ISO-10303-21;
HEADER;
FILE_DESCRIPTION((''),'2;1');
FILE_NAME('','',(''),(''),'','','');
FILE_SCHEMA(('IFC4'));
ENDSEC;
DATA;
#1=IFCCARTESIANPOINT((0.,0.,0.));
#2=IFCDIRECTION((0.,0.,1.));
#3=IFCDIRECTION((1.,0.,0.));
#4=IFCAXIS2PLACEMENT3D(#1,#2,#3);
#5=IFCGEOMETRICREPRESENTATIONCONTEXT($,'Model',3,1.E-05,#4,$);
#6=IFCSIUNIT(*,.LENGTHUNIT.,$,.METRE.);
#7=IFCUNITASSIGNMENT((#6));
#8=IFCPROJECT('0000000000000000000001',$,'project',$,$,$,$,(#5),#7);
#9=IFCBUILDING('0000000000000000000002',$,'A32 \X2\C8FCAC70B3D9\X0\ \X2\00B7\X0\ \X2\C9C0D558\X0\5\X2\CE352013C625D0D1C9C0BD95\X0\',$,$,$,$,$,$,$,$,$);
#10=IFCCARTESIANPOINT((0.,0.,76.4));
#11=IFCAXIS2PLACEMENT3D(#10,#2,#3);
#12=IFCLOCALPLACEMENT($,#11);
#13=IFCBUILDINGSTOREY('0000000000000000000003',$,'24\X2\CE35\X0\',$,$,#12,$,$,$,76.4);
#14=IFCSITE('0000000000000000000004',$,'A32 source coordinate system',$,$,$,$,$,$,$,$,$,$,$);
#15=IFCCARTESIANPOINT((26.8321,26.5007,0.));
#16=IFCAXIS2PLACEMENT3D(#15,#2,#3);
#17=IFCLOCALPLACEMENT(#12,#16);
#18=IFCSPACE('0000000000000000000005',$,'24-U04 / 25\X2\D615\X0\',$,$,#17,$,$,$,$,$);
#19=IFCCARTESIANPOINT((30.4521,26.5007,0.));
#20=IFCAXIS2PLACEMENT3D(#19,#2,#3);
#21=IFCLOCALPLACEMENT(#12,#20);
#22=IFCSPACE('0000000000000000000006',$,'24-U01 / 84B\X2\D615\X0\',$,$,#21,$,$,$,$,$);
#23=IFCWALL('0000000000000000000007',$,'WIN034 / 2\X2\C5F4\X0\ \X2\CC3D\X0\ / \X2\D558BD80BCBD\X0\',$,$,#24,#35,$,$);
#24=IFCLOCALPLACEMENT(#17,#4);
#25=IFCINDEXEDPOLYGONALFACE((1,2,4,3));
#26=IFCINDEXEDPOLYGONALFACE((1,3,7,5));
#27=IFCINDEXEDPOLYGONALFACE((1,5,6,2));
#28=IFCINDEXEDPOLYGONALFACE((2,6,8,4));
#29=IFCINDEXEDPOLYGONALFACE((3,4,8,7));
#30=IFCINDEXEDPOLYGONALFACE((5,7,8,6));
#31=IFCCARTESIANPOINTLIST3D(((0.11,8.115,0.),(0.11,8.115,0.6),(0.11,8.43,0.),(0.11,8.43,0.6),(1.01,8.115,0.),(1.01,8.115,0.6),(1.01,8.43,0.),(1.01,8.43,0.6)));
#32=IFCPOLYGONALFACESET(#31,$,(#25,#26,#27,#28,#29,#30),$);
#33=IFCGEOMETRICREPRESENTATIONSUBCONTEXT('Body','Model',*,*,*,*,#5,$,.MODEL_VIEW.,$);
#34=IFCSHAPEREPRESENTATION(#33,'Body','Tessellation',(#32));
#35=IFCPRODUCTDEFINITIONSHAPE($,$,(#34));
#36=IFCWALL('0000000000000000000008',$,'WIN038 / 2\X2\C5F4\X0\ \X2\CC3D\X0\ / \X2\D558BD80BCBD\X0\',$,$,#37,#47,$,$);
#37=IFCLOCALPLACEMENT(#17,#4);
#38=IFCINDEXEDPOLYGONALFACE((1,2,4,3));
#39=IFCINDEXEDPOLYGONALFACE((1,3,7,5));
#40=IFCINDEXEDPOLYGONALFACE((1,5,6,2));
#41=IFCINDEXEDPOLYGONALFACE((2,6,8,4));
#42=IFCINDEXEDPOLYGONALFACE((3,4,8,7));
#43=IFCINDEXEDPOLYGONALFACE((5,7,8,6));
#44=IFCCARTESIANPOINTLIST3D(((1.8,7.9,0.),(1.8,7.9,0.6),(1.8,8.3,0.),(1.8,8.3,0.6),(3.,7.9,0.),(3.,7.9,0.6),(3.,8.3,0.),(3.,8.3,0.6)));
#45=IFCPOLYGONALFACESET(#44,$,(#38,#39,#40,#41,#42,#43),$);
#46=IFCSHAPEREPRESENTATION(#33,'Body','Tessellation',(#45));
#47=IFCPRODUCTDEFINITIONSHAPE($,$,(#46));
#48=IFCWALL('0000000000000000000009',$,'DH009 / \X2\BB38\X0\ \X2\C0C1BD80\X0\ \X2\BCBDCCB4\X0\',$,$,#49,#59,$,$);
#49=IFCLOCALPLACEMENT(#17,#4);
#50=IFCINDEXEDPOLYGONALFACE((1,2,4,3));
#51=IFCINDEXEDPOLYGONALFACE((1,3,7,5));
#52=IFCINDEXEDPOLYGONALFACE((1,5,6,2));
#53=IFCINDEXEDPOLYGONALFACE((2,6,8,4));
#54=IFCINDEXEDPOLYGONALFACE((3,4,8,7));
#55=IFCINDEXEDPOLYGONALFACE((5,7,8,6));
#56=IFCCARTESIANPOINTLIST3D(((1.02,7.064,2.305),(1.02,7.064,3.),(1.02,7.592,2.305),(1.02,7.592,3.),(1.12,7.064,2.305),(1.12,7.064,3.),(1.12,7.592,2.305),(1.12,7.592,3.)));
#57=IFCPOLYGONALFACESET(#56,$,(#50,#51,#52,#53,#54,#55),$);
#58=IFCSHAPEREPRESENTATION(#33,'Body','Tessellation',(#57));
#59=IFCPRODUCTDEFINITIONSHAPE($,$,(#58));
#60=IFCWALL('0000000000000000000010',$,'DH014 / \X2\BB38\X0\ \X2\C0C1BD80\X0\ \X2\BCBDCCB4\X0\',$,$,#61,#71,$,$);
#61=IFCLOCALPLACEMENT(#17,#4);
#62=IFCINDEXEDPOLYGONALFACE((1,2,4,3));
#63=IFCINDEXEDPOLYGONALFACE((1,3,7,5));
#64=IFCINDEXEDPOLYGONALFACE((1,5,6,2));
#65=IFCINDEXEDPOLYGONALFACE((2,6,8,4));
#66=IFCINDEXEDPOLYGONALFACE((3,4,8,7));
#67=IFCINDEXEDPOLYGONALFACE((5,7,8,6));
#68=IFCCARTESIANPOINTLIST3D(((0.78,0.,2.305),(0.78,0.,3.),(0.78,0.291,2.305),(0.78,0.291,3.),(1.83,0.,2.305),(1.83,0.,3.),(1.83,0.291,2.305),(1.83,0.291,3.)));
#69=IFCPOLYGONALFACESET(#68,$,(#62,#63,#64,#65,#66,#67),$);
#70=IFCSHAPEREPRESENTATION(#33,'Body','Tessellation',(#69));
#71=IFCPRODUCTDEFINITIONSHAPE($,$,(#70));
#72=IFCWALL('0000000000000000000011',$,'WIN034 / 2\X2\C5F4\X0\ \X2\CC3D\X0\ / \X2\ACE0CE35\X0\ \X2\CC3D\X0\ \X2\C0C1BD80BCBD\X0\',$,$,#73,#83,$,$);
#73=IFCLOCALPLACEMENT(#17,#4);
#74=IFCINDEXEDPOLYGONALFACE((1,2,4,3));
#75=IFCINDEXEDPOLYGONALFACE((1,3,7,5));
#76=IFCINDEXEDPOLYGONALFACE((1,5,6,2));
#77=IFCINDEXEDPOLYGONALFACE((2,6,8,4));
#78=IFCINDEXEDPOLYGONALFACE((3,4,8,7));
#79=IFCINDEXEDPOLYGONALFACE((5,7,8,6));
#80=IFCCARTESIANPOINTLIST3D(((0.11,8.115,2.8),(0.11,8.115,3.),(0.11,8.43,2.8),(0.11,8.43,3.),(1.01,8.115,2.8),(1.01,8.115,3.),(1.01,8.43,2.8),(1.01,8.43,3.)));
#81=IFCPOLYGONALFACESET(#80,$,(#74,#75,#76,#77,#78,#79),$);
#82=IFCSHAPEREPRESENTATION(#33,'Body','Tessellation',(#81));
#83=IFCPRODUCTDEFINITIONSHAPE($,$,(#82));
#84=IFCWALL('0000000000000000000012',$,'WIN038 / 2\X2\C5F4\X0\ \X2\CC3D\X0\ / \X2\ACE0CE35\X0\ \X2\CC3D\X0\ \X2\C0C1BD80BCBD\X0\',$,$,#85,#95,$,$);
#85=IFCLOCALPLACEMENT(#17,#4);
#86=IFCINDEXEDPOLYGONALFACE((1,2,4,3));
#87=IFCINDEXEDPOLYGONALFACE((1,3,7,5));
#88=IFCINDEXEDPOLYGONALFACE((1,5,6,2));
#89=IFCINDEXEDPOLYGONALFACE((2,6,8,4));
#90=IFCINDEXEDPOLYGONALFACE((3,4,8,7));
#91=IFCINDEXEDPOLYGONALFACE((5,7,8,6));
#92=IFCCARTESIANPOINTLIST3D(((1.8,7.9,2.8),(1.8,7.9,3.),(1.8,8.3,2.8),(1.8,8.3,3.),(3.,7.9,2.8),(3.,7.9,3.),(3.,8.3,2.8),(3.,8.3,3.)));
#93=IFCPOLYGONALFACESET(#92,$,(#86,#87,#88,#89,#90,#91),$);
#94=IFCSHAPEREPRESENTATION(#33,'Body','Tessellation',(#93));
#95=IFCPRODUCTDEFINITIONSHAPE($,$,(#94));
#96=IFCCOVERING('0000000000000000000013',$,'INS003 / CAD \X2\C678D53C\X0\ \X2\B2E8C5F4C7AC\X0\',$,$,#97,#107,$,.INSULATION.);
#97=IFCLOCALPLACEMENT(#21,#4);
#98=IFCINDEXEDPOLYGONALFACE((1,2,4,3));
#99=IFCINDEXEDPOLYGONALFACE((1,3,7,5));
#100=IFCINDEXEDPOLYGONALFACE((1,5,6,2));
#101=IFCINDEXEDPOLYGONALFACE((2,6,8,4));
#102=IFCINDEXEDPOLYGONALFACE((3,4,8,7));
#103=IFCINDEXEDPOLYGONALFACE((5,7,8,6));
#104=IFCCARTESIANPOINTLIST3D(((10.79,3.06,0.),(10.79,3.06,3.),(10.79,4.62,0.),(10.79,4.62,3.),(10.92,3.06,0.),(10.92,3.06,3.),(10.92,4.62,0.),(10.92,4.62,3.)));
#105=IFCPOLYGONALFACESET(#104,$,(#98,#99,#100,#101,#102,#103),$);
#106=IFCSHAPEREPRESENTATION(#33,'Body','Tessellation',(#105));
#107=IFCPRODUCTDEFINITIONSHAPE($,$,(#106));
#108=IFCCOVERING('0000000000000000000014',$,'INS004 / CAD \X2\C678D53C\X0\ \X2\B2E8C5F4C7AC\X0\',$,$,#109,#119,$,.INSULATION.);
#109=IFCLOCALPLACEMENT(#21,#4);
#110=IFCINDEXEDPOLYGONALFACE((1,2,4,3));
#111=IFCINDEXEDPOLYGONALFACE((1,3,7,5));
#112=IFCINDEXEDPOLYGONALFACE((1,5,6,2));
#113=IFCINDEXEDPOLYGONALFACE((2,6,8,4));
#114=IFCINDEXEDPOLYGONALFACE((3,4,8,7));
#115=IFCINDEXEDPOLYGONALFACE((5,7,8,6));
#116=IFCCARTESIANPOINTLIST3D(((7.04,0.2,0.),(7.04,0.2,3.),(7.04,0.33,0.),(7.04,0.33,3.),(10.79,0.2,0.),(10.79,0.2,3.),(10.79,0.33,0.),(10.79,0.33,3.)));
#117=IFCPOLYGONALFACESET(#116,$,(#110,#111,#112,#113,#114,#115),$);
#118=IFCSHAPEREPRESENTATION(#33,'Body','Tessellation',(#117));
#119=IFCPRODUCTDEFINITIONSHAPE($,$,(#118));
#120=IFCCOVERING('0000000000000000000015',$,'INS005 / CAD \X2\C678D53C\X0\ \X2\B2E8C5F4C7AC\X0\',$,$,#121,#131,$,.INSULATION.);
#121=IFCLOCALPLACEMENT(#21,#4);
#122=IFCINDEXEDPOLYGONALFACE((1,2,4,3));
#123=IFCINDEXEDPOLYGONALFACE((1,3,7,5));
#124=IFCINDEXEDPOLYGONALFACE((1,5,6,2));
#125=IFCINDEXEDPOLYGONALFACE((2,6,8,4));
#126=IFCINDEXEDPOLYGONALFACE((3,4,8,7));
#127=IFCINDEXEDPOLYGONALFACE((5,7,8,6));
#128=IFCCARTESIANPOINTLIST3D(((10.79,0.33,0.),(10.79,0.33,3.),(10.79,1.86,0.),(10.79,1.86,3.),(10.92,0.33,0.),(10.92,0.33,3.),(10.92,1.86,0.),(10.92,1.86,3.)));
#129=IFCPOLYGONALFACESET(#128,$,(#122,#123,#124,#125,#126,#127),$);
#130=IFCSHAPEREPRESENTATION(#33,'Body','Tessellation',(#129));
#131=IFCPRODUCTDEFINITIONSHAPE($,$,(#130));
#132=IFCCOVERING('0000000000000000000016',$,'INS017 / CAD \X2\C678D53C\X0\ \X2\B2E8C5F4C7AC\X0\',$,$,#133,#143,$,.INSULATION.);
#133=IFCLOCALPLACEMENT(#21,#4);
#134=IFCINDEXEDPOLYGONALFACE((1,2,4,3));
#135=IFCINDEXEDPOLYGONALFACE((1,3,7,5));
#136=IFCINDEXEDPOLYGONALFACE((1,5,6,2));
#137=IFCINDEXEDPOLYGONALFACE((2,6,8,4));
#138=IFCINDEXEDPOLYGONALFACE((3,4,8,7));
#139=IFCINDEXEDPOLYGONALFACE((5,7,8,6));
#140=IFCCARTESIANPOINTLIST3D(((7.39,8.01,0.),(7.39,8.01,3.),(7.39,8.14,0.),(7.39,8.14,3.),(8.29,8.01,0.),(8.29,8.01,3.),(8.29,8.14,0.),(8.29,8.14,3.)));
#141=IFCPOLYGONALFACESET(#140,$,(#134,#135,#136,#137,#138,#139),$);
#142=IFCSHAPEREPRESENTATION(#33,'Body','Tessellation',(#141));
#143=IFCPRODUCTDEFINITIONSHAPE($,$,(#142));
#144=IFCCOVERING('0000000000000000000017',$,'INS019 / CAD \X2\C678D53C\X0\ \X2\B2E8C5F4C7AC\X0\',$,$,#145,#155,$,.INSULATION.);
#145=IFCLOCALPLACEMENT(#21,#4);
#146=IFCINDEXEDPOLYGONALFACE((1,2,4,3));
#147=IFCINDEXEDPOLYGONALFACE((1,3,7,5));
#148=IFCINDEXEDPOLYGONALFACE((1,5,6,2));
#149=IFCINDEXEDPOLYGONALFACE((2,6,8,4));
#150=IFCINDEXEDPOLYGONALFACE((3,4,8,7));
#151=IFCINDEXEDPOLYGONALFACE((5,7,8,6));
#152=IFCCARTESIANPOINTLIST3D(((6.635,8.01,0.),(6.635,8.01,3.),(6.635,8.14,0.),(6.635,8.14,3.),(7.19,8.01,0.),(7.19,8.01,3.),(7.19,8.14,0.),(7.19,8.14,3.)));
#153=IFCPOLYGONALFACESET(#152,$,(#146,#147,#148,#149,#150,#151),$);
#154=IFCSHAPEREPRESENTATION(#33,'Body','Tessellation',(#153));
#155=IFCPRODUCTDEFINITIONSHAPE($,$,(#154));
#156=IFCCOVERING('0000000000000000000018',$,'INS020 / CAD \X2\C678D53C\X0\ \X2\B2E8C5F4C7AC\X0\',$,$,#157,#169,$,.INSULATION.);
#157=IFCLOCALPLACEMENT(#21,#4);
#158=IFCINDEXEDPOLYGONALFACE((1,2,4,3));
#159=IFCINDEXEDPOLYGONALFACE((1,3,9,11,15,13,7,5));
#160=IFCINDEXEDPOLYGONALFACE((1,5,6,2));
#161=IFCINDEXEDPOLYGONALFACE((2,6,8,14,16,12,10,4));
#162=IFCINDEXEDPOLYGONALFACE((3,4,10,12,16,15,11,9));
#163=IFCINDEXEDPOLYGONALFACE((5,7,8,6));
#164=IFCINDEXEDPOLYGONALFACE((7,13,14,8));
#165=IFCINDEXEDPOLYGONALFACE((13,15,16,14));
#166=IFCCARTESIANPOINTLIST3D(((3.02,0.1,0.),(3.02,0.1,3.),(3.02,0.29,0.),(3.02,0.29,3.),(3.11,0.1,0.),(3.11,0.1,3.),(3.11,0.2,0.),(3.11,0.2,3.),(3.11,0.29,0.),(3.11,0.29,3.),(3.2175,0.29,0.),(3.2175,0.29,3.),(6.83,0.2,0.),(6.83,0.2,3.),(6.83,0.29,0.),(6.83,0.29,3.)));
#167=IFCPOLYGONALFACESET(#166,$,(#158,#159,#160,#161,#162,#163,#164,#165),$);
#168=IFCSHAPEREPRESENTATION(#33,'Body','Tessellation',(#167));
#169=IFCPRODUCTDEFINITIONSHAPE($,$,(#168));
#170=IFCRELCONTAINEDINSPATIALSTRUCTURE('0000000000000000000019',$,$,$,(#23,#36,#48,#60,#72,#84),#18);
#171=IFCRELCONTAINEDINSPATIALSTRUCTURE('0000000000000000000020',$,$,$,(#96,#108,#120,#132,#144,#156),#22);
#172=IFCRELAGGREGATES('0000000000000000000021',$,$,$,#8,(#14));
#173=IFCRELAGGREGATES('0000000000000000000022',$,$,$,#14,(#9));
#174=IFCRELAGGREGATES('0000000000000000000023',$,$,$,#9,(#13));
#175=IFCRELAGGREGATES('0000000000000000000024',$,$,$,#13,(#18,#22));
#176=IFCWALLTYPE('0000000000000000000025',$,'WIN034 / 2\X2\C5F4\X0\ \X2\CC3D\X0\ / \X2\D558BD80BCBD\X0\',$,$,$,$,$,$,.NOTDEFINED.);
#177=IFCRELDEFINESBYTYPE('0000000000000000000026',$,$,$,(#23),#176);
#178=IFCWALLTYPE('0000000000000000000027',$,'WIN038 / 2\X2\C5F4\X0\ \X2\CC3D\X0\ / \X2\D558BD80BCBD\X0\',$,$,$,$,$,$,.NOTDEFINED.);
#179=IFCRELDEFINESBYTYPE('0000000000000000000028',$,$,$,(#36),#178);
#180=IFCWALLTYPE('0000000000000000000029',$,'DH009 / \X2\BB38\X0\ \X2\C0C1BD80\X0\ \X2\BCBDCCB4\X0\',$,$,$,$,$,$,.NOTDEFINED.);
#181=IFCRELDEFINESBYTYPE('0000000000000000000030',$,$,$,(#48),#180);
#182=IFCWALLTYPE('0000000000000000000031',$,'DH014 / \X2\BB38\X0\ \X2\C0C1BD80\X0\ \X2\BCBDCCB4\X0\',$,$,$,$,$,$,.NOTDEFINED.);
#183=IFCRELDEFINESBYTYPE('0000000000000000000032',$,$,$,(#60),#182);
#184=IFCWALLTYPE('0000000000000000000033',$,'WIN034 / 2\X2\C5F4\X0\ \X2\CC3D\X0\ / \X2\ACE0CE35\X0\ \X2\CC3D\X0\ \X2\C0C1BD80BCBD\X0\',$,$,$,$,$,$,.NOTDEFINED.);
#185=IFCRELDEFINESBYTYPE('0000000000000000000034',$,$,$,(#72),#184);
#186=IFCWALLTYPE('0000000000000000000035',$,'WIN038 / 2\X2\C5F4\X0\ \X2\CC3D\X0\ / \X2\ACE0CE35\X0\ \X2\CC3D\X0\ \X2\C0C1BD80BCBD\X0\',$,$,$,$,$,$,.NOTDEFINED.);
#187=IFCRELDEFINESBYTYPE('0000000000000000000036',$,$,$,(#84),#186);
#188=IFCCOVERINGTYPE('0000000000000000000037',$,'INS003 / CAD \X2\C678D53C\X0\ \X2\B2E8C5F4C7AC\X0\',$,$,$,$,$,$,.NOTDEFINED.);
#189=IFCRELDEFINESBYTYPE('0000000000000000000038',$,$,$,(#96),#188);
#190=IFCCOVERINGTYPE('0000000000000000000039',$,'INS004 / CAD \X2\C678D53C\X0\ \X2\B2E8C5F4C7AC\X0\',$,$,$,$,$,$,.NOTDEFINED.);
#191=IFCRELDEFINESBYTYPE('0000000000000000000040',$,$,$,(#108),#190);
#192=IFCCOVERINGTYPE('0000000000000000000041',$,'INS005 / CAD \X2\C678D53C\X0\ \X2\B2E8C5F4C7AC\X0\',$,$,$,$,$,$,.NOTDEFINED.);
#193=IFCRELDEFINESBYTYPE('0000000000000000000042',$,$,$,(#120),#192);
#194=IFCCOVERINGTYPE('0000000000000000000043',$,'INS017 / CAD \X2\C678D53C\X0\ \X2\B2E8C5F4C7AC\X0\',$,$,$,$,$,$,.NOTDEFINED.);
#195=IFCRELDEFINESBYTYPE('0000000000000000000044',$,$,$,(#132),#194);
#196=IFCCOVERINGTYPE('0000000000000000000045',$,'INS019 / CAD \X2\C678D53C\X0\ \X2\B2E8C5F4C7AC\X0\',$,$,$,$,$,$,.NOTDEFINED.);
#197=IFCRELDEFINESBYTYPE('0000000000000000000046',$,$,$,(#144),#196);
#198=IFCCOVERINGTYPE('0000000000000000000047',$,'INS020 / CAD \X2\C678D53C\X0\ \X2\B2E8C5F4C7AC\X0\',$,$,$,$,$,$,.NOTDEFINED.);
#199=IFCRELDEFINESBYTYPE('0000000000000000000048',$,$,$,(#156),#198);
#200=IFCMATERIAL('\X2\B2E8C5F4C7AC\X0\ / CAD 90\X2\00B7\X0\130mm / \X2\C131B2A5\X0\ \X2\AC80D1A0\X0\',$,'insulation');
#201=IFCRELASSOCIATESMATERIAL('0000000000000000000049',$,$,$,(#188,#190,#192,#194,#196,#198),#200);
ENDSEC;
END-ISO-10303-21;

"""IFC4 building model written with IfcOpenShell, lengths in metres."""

from ifc_helpers import new_model, si_unit, frame, origin, origin_with_axes, place, context, subcontext, project, spatial, polyline, outline, extrude, source, transform, mapped, material, type_object, type_shapes, element, save


model = new_model("IFC4")

# Units and contexts
model_context = context("Model", 3, precision=1e-05, world=origin_with_axes())
body_context = subcontext(model_context, "Body", "Model", "MODEL_VIEW")
ifc_project = project(units=[si_unit("LENGTHUNIT", "METRE")], contexts=[model_context])

# Site, building, storey, space
site = spatial("IfcSite", under=ifc_project, Name="A32 source coordinate system")
building = spatial("IfcBuilding", under=site, Name="A32 주거동 · 지하5층–옥탑지붕")
storey_placement = place(None, frame((0.0, 0.0, 76.4), z_axis=(0.0, 0.0, 1.0), x_axis=(1.0, 0.0, 0.0)))
storey = spatial("IfcBuildingStorey", under=building, at=storey_placement, Name="24층", Elevation=76.4)
space_1_placement = place(storey_placement, frame((26.8321, 26.5007, 0.0), z_axis=(0.0, 0.0, 1.0), x_axis=(1.0, 0.0, 0.0)))
space_1 = spatial("IfcSpace", under=storey, at=space_1_placement, Name="24-U04 / 25형")

# Walls
wall_type_1 = type_object("IfcWallType", Name="WIN034 / 2열 창 / 하부벽", PredefinedType="NOTDEFINED")
shared_shape_1 = source(origin(), body_context, "Body", "SweptSolid", [
    extrude(outline(polyline([(0.11, 8.115), (0.11, 8.43), (1.01, 8.43), (1.01, 8.115), (0.11, 8.115)])), origin(), (0.0, 0.0, 1.0), 0.6),
])
type_shapes(wall_type_1, [shared_shape_1])
wall_1_placement = place(space_1_placement, origin_with_axes())
element("IfcWall", 1, at=wall_1_placement, inside=space_1, type_object=wall_type_1, Name="WIN034 / 2열 창 / 하부벽", context=body_context, shape_type="MappedRepresentation", body=[
    mapped(shared_shape_1, transform((0.0, 0.0, 0.0), scale=1.0)),
])
wall_type_2 = type_object("IfcWallType", Name="WIN038 / 2열 창 / 하부벽", PredefinedType="NOTDEFINED")
shared_shape_2 = source(origin(), body_context, "Body", "SweptSolid", [
    extrude(outline(polyline([(1.8, 7.9), (1.8, 8.3), (3.0, 8.3), (3.0, 7.9), (1.8, 7.9)])), origin(), (0.0, 0.0, 1.0), 0.6),
])
type_shapes(wall_type_2, [shared_shape_2])
wall_2_placement = place(space_1_placement, origin_with_axes())
element("IfcWall", 2, at=wall_2_placement, inside=space_1, type_object=wall_type_2, Name="WIN038 / 2열 창 / 하부벽", context=body_context, shape_type="MappedRepresentation", body=[
    mapped(shared_shape_2, transform((0.0, 0.0, 0.0), scale=1.0)),
])
wall_type_3 = type_object("IfcWallType", Name="DH009 / 문 상부 벽체", PredefinedType="NOTDEFINED")
shared_shape_3 = source(origin(), body_context, "Body", "SweptSolid", [
    extrude(outline(polyline([(1.02, 7.064), (1.02, 7.592), (1.12, 7.592), (1.12, 7.064), (1.02, 7.064)])), frame((0.0, 0.0, 2.305)), (0.0, 0.0, 1.0), 0.695),
])
type_shapes(wall_type_3, [shared_shape_3])
wall_3_placement = place(space_1_placement, origin_with_axes())
element("IfcWall", 3, at=wall_3_placement, inside=space_1, type_object=wall_type_3, Name="DH009 / 문 상부 벽체", context=body_context, shape_type="MappedRepresentation", body=[
    mapped(shared_shape_3, transform((0.0, 0.0, 0.0), scale=1.0)),
])
wall_type_4 = type_object("IfcWallType", Name="DH014 / 문 상부 벽체", PredefinedType="NOTDEFINED")
shared_shape_4 = source(origin(), body_context, "Body", "SweptSolid", [
    extrude(outline(polyline([(0.78, 0.291), (1.83, 0.291), (1.83, 0.0), (0.78, 0.0), (0.78, 0.291)])), frame((0.0, 0.0, 2.305)), (0.0, 0.0, 1.0), 0.695),
])
type_shapes(wall_type_4, [shared_shape_4])
wall_4_placement = place(space_1_placement, origin_with_axes())
element("IfcWall", 4, at=wall_4_placement, inside=space_1, type_object=wall_type_4, Name="DH014 / 문 상부 벽체", context=body_context, shape_type="MappedRepresentation", body=[
    mapped(shared_shape_4, transform((0.0, 0.0, 0.0), scale=1.0)),
])
wall_type_5 = type_object("IfcWallType", Name="WIN034 / 2열 창 / 고층 창 상부벽", PredefinedType="NOTDEFINED")
shared_shape_5 = source(origin(), body_context, "Body", "SweptSolid", [
    extrude(outline(polyline([(1.01, 8.115), (1.01, 8.43), (0.11, 8.43), (0.11, 8.115), (1.01, 8.115)])), frame((0.0, 0.0, 2.8)), (0.0, 0.0, 1.0), 0.2),
])
type_shapes(wall_type_5, [shared_shape_5])
wall_5_placement = place(space_1_placement, origin_with_axes())
element("IfcWall", 5, at=wall_5_placement, inside=space_1, type_object=wall_type_5, Name="WIN034 / 2열 창 / 고층 창 상부벽", context=body_context, shape_type="MappedRepresentation", body=[
    mapped(shared_shape_5, transform((0.0, 0.0, 0.0), scale=1.0)),
])
wall_type_6 = type_object("IfcWallType", Name="WIN038 / 2열 창 / 고층 창 상부벽", PredefinedType="NOTDEFINED")
shared_shape_6 = source(origin(), body_context, "Body", "SweptSolid", [
    extrude(outline(polyline([(3.0, 7.9), (3.0, 8.3), (1.8, 8.3), (1.8, 7.9), (3.0, 7.9)])), frame((0.0, 0.0, 2.8)), (0.0, 0.0, 1.0), 0.2),
])
type_shapes(wall_type_6, [shared_shape_6])
wall_6_placement = place(space_1_placement, origin_with_axes())
element("IfcWall", 6, at=wall_6_placement, inside=space_1, type_object=wall_type_6, Name="WIN038 / 2열 창 / 고층 창 상부벽", context=body_context, shape_type="MappedRepresentation", body=[
    mapped(shared_shape_6, transform((0.0, 0.0, 0.0), scale=1.0)),
])

# Shared definitions
space_2_placement = place(storey_placement, frame((30.4521, 26.5007, 0.0), z_axis=(0.0, 0.0, 1.0), x_axis=(1.0, 0.0, 0.0)))
space_2 = spatial("IfcSpace", under=storey, at=space_2_placement, Name="24-U01 / 84B형")

# Coverings
ifc_material = material(Name="단열재 / CAD 90·130mm / 성능 검토", Category="insulation")
covering_type_1 = type_object("IfcCoveringType", Name="INS003 / CAD 외피 단열재", PredefinedType="NOTDEFINED", material=ifc_material)
shared_shape_7 = source(origin(), body_context, "Body", "SweptSolid", [
    extrude(outline(polyline([(10.79, 3.06), (10.79, 4.62), (10.92, 4.62), (10.92, 3.06), (10.79, 3.06)])), origin(), (0.0, 0.0, 1.0), 3.0),
])
type_shapes(covering_type_1, [shared_shape_7])
covering_1_placement = place(space_2_placement, origin_with_axes())
element("IfcCovering", 7, at=covering_1_placement, inside=space_2, type_object=covering_type_1, Name="INS003 / CAD 외피 단열재", PredefinedType="INSULATION", context=body_context, shape_type="MappedRepresentation", body=[
    mapped(shared_shape_7, transform((0.0, 0.0, 0.0), scale=1.0)),
])
covering_type_2 = type_object("IfcCoveringType", Name="INS004 / CAD 외피 단열재", PredefinedType="NOTDEFINED", material=ifc_material)
shared_shape_8 = source(origin(), body_context, "Body", "SweptSolid", [
    extrude(outline(polyline([(7.04, 0.33), (10.79, 0.33), (10.79, 0.2), (7.04, 0.2), (7.04, 0.33)])), origin(), (0.0, 0.0, 1.0), 3.0),
])
type_shapes(covering_type_2, [shared_shape_8])
covering_2_placement = place(space_2_placement, origin_with_axes())
element("IfcCovering", 8, at=covering_2_placement, inside=space_2, type_object=covering_type_2, Name="INS004 / CAD 외피 단열재", PredefinedType="INSULATION", context=body_context, shape_type="MappedRepresentation", body=[
    mapped(shared_shape_8, transform((0.0, 0.0, 0.0), scale=1.0)),
])
covering_type_3 = type_object("IfcCoveringType", Name="INS005 / CAD 외피 단열재", PredefinedType="NOTDEFINED", material=ifc_material)
shared_shape_9 = source(origin(), body_context, "Body", "SweptSolid", [
    extrude(outline(polyline([(10.79, 0.33), (10.79, 1.86), (10.92, 1.86), (10.92, 0.33), (10.79, 0.33)])), origin(), (0.0, 0.0, 1.0), 3.0),
])
type_shapes(covering_type_3, [shared_shape_9])
covering_3_placement = place(space_2_placement, origin_with_axes())
element("IfcCovering", 9, at=covering_3_placement, inside=space_2, type_object=covering_type_3, Name="INS005 / CAD 외피 단열재", PredefinedType="INSULATION", context=body_context, shape_type="MappedRepresentation", body=[
    mapped(shared_shape_9, transform((0.0, 0.0, 0.0), scale=1.0)),
])
covering_type_4 = type_object("IfcCoveringType", Name="INS017 / CAD 외피 단열재", PredefinedType="NOTDEFINED", material=ifc_material)
shared_shape_10 = source(origin(), body_context, "Body", "SweptSolid", [
    extrude(outline(polyline([(8.29, 8.01), (7.39, 8.01), (7.39, 8.14), (8.29, 8.14), (8.29, 8.01)])), origin(), (0.0, 0.0, 1.0), 3.0),
])
type_shapes(covering_type_4, [shared_shape_10])
covering_4_placement = place(space_2_placement, origin_with_axes())
element("IfcCovering", 10, at=covering_4_placement, inside=space_2, type_object=covering_type_4, Name="INS017 / CAD 외피 단열재", PredefinedType="INSULATION", context=body_context, shape_type="MappedRepresentation", body=[
    mapped(shared_shape_10, transform((0.0, 0.0, 0.0), scale=1.0)),
])
covering_type_5 = type_object("IfcCoveringType", Name="INS019 / CAD 외피 단열재", PredefinedType="NOTDEFINED", material=ifc_material)
shared_shape_11 = source(origin(), body_context, "Body", "SweptSolid", [
    extrude(outline(polyline([(6.635, 8.01), (6.635, 8.14), (7.19, 8.14), (7.19, 8.01), (6.635, 8.01)])), origin(), (0.0, 0.0, 1.0), 3.0),
])
type_shapes(covering_type_5, [shared_shape_11])
covering_5_placement = place(space_2_placement, origin_with_axes())
element("IfcCovering", 11, at=covering_5_placement, inside=space_2, type_object=covering_type_5, Name="INS019 / CAD 외피 단열재", PredefinedType="INSULATION", context=body_context, shape_type="MappedRepresentation", body=[
    mapped(shared_shape_11, transform((0.0, 0.0, 0.0), scale=1.0)),
])
covering_type_6 = type_object("IfcCoveringType", Name="INS020 / CAD 외피 단열재", PredefinedType="NOTDEFINED", material=ifc_material)
shared_shape_12 = source(origin(), body_context, "Body", "SweptSolid", [
    extrude(outline(polyline([(3.11, 0.2), (3.11, 0.1), (3.02, 0.1), (3.02, 0.29), (3.11, 0.29), (3.2175, 0.29), (6.83, 0.29), (6.83, 0.2), (3.11, 0.2)])), origin(), (0.0, 0.0, 1.0), 3.0),
])
type_shapes(covering_type_6, [shared_shape_12])
covering_6_placement = place(space_2_placement, origin_with_axes())
element("IfcCovering", 12, at=covering_6_placement, inside=space_2, type_object=covering_type_6, Name="INS020 / CAD 외피 단열재", PredefinedType="INSULATION", context=body_context, shape_type="MappedRepresentation", body=[
    mapped(shared_shape_12, transform((0.0, 0.0, 0.0), scale=1.0)),
])

save(model, "model.ifc")
